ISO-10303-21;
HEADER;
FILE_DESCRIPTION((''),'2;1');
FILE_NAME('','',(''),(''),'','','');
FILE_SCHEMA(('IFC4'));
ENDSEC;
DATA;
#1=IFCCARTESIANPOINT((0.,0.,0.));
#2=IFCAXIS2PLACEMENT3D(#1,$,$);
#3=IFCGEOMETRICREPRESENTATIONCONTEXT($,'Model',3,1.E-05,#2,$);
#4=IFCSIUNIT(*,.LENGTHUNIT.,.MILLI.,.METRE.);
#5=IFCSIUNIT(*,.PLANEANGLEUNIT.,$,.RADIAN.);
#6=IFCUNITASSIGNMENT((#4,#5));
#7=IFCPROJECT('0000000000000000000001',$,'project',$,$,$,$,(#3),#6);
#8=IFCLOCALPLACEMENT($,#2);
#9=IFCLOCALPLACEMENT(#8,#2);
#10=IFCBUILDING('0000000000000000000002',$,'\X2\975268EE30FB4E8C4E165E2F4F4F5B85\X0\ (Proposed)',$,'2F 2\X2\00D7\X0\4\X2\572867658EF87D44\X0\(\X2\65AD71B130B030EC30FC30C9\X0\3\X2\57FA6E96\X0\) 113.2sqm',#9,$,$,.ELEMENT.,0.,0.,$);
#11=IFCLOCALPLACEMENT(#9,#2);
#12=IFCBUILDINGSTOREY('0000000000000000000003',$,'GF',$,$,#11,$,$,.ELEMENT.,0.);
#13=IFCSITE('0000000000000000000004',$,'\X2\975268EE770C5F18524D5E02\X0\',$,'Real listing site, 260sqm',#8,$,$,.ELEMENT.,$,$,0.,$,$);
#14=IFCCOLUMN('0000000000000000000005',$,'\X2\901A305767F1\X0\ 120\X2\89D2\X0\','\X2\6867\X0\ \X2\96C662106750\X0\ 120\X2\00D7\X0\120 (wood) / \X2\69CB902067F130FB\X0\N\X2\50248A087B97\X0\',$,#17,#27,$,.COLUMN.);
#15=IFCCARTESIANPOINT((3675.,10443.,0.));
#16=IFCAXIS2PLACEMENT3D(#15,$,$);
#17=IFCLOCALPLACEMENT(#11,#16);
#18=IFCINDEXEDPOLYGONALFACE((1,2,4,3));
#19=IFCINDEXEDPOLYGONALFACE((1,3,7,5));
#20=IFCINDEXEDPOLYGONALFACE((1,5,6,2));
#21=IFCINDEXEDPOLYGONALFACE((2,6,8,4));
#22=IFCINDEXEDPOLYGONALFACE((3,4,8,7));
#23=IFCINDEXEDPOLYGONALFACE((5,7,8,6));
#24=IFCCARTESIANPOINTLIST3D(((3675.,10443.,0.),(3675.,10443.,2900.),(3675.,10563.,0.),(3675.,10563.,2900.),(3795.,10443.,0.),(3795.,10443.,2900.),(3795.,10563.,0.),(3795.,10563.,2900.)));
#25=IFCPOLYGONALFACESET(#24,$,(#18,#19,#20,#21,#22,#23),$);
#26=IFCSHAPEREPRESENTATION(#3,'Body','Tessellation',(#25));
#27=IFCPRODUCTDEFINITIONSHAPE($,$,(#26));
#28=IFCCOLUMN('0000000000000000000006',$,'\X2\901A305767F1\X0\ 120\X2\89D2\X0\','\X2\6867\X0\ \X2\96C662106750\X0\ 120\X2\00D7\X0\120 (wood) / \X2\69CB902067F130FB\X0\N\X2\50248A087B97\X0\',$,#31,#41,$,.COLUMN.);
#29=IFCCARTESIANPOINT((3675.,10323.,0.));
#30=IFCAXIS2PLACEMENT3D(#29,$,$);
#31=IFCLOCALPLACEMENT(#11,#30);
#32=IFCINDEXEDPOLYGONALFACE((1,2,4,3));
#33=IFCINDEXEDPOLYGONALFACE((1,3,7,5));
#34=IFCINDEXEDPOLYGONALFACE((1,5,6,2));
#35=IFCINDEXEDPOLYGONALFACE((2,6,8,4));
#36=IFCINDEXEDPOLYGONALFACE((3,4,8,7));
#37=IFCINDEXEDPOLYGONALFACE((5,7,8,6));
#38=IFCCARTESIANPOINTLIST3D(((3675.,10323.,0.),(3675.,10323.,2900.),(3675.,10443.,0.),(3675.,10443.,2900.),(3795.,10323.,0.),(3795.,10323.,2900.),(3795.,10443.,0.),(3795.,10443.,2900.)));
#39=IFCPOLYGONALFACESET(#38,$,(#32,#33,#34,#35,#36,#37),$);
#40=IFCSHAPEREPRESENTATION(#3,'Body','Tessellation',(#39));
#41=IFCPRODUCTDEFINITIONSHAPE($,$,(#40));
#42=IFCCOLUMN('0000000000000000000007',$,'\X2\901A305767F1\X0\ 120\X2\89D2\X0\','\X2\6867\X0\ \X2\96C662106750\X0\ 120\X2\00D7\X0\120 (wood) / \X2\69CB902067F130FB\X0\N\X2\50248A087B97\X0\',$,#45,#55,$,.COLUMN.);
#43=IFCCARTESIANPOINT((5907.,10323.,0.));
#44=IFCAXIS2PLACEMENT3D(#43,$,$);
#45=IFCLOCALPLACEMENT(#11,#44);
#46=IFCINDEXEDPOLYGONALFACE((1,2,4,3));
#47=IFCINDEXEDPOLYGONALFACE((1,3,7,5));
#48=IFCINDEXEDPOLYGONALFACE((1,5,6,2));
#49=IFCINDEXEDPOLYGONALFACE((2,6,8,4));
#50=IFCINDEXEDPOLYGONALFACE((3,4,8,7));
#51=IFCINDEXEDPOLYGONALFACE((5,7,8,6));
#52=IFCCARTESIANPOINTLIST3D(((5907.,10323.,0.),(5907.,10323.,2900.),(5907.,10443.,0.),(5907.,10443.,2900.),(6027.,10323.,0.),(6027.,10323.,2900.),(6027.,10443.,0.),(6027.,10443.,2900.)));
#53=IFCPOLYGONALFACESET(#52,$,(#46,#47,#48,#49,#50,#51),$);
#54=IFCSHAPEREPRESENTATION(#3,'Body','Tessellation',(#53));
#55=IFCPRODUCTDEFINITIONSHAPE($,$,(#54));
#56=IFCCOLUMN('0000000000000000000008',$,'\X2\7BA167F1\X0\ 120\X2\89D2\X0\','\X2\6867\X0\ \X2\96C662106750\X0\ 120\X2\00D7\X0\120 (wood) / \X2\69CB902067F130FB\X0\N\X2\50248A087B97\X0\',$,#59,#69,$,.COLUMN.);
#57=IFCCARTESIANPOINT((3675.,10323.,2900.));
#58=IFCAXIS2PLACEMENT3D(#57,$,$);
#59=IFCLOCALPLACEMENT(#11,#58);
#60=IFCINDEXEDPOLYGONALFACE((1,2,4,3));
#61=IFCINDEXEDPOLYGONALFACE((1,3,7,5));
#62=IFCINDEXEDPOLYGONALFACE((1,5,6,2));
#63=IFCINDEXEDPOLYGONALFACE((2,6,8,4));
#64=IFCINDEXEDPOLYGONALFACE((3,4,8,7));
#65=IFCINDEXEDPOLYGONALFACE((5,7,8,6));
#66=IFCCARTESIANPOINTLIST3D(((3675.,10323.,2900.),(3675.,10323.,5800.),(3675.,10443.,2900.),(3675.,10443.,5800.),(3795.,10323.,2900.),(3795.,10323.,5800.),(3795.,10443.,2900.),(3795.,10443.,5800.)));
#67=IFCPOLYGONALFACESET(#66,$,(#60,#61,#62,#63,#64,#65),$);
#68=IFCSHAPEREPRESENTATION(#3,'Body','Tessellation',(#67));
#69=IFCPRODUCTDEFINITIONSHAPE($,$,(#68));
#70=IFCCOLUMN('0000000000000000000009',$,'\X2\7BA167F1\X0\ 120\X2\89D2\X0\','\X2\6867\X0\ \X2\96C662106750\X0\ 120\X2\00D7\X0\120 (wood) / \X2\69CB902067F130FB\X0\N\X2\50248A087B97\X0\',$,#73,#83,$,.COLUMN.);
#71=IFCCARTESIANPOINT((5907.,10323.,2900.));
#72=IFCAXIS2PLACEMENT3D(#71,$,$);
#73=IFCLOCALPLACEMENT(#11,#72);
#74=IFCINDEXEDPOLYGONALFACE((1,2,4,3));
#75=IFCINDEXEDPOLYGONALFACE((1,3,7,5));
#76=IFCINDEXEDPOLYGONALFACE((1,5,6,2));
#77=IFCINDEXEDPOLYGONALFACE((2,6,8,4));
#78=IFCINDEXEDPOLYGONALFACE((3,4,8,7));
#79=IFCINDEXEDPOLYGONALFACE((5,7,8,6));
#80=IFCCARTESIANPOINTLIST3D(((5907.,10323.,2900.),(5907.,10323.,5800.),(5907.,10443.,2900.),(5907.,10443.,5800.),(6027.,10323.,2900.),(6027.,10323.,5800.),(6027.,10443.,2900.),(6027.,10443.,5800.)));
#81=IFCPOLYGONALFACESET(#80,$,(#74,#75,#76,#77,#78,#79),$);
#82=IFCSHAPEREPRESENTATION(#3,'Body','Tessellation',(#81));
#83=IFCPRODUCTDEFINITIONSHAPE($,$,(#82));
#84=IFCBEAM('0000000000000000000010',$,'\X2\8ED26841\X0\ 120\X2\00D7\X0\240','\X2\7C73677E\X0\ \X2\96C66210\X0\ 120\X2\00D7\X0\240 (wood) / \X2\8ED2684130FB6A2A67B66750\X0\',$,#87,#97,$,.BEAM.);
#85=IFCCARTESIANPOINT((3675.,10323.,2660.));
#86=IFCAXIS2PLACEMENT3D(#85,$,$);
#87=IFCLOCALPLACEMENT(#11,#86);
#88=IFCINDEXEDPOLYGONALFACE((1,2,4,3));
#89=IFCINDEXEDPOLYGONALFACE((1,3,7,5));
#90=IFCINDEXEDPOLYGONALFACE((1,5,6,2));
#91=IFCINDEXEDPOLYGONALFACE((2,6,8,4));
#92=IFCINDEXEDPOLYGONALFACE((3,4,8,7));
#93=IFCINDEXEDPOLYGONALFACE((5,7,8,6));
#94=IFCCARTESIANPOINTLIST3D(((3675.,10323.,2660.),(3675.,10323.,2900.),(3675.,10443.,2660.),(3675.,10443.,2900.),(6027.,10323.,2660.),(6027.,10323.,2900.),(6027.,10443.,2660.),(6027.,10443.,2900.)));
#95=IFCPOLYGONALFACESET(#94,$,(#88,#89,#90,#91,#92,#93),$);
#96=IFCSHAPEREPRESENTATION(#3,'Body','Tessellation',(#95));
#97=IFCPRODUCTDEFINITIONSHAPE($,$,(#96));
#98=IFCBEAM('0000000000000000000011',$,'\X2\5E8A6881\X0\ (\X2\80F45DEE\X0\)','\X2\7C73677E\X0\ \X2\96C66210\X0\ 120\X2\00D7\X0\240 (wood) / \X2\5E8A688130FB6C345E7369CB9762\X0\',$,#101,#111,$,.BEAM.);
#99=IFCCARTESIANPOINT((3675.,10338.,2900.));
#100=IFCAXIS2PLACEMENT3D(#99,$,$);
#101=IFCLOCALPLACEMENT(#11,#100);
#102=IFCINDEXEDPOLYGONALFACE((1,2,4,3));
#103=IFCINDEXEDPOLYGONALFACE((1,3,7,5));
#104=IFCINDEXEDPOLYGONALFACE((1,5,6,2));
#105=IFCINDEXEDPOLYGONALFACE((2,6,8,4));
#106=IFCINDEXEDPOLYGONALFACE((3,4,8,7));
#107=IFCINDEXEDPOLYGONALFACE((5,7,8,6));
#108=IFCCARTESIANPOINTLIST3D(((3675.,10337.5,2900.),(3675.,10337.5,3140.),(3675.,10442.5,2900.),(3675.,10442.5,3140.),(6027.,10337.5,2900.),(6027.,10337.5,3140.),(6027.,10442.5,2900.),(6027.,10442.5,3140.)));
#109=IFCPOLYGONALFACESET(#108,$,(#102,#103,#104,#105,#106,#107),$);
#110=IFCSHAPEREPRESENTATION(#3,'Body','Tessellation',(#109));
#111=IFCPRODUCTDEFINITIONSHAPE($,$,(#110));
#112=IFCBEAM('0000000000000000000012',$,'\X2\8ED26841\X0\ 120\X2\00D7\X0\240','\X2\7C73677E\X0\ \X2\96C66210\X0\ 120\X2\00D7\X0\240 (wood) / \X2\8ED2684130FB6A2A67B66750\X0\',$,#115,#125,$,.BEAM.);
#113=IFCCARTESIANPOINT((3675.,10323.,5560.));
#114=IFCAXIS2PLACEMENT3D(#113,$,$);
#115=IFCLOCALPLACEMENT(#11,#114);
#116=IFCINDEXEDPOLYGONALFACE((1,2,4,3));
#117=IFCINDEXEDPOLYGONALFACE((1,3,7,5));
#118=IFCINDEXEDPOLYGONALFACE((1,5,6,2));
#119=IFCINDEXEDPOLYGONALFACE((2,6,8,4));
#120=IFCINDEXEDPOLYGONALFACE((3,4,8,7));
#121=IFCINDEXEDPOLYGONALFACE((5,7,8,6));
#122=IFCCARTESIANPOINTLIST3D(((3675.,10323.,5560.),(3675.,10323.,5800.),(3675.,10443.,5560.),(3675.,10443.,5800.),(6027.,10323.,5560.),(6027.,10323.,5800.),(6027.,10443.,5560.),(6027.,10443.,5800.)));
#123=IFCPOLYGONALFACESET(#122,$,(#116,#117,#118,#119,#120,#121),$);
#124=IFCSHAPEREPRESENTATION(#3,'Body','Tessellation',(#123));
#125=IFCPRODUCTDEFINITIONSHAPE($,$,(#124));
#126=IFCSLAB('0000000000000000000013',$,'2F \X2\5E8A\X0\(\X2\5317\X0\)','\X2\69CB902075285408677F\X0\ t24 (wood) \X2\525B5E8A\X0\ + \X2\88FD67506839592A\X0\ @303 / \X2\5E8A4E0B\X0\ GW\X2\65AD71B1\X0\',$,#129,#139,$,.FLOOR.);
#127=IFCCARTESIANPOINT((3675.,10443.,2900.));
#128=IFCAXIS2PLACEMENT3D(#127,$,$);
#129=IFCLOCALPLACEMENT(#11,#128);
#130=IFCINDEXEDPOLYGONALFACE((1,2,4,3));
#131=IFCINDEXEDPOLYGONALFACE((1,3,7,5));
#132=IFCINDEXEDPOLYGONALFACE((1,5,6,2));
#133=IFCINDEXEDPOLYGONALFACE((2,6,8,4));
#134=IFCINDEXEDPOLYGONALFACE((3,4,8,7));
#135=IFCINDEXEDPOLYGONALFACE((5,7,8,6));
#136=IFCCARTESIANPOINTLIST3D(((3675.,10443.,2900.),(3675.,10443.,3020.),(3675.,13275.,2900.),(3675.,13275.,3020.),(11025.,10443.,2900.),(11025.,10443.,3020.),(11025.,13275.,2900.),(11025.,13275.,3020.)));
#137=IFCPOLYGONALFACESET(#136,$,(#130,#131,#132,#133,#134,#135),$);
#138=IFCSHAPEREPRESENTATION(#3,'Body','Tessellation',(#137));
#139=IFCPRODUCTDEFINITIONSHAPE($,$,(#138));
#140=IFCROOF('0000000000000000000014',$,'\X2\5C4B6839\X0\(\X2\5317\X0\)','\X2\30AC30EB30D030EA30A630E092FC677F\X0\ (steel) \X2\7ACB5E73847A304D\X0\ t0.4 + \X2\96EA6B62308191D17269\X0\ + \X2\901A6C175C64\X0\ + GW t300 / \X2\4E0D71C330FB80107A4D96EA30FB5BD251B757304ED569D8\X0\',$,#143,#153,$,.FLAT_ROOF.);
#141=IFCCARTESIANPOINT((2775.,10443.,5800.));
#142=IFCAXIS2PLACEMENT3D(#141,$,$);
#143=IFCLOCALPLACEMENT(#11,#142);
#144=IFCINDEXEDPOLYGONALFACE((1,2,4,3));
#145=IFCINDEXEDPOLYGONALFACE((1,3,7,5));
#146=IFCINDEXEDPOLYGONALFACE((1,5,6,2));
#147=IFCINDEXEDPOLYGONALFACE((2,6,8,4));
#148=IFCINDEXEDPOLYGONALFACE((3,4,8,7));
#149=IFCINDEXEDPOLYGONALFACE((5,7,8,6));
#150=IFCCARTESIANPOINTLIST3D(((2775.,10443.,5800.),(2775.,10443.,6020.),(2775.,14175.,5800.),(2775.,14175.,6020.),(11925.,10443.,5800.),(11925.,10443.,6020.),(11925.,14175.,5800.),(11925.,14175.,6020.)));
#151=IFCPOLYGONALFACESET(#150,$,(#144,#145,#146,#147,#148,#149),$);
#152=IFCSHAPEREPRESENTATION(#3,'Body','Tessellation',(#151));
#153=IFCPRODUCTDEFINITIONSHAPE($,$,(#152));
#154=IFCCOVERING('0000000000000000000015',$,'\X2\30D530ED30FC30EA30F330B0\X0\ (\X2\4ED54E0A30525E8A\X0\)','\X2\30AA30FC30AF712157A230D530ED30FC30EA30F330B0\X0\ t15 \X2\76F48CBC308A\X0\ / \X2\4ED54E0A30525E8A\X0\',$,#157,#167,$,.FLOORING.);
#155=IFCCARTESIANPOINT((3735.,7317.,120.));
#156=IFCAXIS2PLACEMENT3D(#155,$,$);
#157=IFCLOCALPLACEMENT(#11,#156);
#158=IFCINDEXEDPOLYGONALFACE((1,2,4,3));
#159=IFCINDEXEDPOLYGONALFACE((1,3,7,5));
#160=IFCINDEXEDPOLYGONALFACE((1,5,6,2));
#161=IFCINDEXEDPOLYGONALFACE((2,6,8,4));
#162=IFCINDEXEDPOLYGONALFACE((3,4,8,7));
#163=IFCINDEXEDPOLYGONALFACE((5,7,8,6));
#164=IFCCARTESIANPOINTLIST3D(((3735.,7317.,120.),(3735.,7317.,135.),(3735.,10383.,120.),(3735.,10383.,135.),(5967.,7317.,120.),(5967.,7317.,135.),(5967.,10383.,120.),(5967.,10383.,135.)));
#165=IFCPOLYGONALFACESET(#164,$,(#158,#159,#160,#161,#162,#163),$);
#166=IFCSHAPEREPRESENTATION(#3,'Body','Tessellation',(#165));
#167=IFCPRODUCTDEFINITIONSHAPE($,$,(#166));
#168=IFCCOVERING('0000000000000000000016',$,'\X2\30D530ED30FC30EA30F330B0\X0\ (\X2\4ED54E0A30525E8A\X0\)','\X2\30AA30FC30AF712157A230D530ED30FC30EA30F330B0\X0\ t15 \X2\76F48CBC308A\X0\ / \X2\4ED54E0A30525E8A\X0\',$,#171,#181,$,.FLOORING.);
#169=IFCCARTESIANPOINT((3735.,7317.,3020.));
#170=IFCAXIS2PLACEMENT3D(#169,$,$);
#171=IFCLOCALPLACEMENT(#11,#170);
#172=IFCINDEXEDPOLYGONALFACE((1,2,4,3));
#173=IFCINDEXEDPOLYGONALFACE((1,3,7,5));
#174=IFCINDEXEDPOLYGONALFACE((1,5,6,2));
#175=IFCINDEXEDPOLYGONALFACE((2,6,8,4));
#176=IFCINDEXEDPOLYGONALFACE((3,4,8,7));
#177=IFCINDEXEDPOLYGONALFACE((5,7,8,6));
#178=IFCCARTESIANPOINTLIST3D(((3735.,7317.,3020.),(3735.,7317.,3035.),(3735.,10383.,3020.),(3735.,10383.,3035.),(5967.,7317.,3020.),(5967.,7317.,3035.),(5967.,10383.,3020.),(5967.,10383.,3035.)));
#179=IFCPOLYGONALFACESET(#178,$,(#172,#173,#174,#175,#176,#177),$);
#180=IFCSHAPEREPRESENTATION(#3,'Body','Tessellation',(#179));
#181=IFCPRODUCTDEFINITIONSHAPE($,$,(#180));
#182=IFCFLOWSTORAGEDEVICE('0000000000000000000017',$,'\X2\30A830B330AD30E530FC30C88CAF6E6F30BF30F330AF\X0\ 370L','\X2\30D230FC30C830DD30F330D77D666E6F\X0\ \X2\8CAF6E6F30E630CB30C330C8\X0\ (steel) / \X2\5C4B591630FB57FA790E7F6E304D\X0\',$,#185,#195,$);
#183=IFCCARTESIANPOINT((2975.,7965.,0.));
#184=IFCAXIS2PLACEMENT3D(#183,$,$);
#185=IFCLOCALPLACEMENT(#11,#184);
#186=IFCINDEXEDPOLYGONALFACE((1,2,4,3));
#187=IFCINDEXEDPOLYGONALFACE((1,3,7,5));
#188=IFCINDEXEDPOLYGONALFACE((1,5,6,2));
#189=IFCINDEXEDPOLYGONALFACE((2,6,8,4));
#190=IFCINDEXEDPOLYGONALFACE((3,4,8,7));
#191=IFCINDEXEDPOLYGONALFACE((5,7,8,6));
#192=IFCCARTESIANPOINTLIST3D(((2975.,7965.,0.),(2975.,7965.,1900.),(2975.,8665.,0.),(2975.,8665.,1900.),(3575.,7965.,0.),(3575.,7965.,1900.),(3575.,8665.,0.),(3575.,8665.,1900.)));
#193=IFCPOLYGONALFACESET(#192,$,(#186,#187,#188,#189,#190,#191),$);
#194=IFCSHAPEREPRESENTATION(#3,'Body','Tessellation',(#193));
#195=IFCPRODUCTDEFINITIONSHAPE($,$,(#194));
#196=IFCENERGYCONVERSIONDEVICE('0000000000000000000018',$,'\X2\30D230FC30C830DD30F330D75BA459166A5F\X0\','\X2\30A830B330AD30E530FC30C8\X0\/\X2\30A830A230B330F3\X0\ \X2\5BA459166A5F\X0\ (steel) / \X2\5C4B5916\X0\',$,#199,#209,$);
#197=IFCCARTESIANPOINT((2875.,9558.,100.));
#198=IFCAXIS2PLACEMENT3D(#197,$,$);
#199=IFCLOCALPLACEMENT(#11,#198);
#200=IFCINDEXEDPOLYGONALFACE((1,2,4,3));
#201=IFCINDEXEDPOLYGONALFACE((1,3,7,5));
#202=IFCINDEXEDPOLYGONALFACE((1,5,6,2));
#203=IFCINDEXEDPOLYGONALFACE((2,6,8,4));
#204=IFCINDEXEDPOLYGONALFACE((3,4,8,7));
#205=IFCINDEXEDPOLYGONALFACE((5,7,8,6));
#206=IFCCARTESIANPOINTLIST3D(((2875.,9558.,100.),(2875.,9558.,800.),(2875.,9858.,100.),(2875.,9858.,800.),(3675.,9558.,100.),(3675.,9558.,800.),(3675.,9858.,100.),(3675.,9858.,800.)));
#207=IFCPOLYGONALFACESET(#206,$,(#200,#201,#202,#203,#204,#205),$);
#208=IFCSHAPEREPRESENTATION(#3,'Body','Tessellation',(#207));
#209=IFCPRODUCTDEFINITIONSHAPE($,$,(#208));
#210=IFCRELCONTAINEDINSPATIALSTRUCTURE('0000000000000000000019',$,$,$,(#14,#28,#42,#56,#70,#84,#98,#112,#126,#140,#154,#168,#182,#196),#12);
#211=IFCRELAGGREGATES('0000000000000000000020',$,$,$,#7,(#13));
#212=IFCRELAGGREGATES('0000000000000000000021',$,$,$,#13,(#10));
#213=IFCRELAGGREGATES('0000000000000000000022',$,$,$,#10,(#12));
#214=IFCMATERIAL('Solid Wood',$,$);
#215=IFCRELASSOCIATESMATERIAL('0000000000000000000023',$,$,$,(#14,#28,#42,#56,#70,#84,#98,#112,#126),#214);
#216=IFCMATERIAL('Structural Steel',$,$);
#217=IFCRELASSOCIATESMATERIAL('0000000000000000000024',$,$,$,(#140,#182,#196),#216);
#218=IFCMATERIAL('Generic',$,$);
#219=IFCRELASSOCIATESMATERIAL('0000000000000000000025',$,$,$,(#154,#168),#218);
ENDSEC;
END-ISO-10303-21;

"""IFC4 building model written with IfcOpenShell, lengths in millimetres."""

from ifc_helpers import new_model, si_unit, frame, frame_2d, origin, place, context, project, spatial, rectangle, extrude, material, element, save


model = new_model("IFC4")

# Units and contexts
model_context = context("Model", 3, precision=1e-05, world=origin())
ifc_project = project(units=[si_unit("LENGTHUNIT", "METRE", prefix="MILLI"), si_unit("PLANEANGLEUNIT", "RADIAN")], contexts=[model_context])

# Site, building, storey
site_placement = place(None, origin())
site = spatial("IfcSite", under=ifc_project, at=site_placement, Name="青森県弘前市", ObjectType="Real listing site, 260sqm", CompositionType="ELEMENT", RefElevation=0.0)
building_placement = place(site_placement, origin())
building = spatial("IfcBuilding", under=site, at=building_placement, Name="青森・二世帯住宅 (Proposed)", ObjectType="2F 2×4在来軸組(断熱グレード3基準) 113.2sqm", CompositionType="ELEMENT", ElevationOfRefHeight=0.0, ElevationOfTerrain=0.0)
storey_placement = place(building_placement, origin())
storey = spatial("IfcBuildingStorey", under=building, at=storey_placement, Name="GF", CompositionType="ELEMENT", Elevation=0.0)

# Columns
ifc_material_1 = material(Name="Solid Wood")
column_1_placement = place(storey_placement, frame((3675.0, 10443.0, 0.0)))
element("IfcColumn", 1, at=column_1_placement, inside=storey, material=ifc_material_1, Name="通し柱 120角", Description="桧 集成材 120×120 (wood) / 構造柱・N値計算", PredefinedType="COLUMN", context=model_context, shape_type="SweptSolid", body=[
    extrude(rectangle(XDim=120.0, YDim=120.0, at=frame_2d((60.0, 60.0))), frame((3675.0, 10443.0, 0.0)), (0.0, 0.0, 1.0), 2900.0),
])
column_2_placement = place(storey_placement, frame((3675.0, 10323.0, 0.0)))
element("IfcColumn", 2, at=column_2_placement, inside=storey, material=ifc_material_1, Name="通し柱 120角", Description="桧 集成材 120×120 (wood) / 構造柱・N値計算", PredefinedType="COLUMN", context=model_context, shape_type="SweptSolid", body=[
    extrude(rectangle(XDim=120.0, YDim=120.0, at=frame_2d((60.0, 60.0))), frame((3675.0, 10323.0, 0.0)), (0.0, 0.0, 1.0), 2900.0),
])
column_3_placement = place(storey_placement, frame((5907.0, 10323.0, 0.0)))
element("IfcColumn", 3, at=column_3_placement, inside=storey, material=ifc_material_1, Name="通し柱 120角", Description="桧 集成材 120×120 (wood) / 構造柱・N値計算", PredefinedType="COLUMN", context=model_context, shape_type="SweptSolid", body=[
    extrude(rectangle(XDim=120.0, YDim=120.0, at=frame_2d((60.0, 60.0))), frame((5907.0, 10323.0, 0.0)), (0.0, 0.0, 1.0), 2900.0),
])
column_4_placement = place(storey_placement, frame((3675.0, 10323.0, 2900.0)))
element("IfcColumn", 4, at=column_4_placement, inside=storey, material=ifc_material_1, Name="管柱 120角", Description="桧 集成材 120×120 (wood) / 構造柱・N値計算", PredefinedType="COLUMN", context=model_context, shape_type="SweptSolid", body=[
    extrude(rectangle(XDim=120.0, YDim=120.0, at=frame_2d((60.0, 60.0))), frame((3675.0, 10323.0, 2900.0)), (0.0, 0.0, 1.0), 2900.0),
])
column_5_placement = place(storey_placement, frame((5907.0, 10323.0, 2900.0)))
element("IfcColumn", 5, at=column_5_placement, inside=storey, material=ifc_material_1, Name="管柱 120角", Description="桧 集成材 120×120 (wood) / 構造柱・N値計算", PredefinedType="COLUMN", context=model_context, shape_type="SweptSolid", body=[
    extrude(rectangle(XDim=120.0, YDim=120.0, at=frame_2d((60.0, 60.0))), frame((5907.0, 10323.0, 2900.0)), (0.0, 0.0, 1.0), 2900.0),
])

# Beams
beam_1_placement = place(storey_placement, frame((3675.0, 10323.0, 2660.0)))
element("IfcBeam", 6, at=beam_1_placement, inside=storey, material=ifc_material_1, Name="軒桁 120×240", Description="米松 集成 120×240 (wood) / 軒桁・横架材", PredefinedType="BEAM", context=model_context, shape_type="SweptSolid", body=[
    extrude(rectangle(XDim=2352.0, YDim=120.0, at=frame_2d((1176.0, 60.0))), frame((3675.0, 10323.0, 2660.0)), (0.0, 0.0, 1.0), 240.0),
])
beam_2_placement = place(storey_placement, frame((3675.0, 10338.0, 2900.0)))
element("IfcBeam", 7, at=beam_2_placement, inside=storey, material=ifc_material_1, Name="床梁 (胴差)", Description="米松 集成 120×240 (wood) / 床梁・水平構面", PredefinedType="BEAM", context=model_context, shape_type="SweptSolid", body=[
    extrude(rectangle(XDim=2352.0, YDim=105.0, at=frame_2d((1176.0, 52.0))), frame((3675.0, 10338.0, 2900.0)), (0.0, 0.0, 1.0), 240.0),
])
beam_3_placement = place(storey_placement, frame((3675.0, 10323.0, 5560.0)))
element("IfcBeam", 8, at=beam_3_placement, inside=storey, material=ifc_material_1, Name="軒桁 120×240", Description="米松 集成 120×240 (wood) / 軒桁・横架材", PredefinedType="BEAM", context=model_context, shape_type="SweptSolid", body=[
    extrude(rectangle(XDim=2352.0, YDim=120.0, at=frame_2d((1176.0, 60.0))), frame((3675.0, 10323.0, 5560.0)), (0.0, 0.0, 1.0), 240.0),
])

# Slab
slab_1_placement = place(storey_placement, frame((3675.0, 10443.0, 2900.0)))
element("IfcSlab", 9, at=slab_1_placement, inside=storey, material=ifc_material_1, Name="2F 床(北)", Description="構造用合板 t24 (wood) 剛床 + 製材根太 @303 / 床下 GW断熱", PredefinedType="FLOOR", context=model_context, shape_type="SweptSolid", body=[
    extrude(rectangle(XDim=7350.0, YDim=2832.0, at=frame_2d((3675.0, 1416.0))), frame((3675.0, 10443.0, 2900.0)), (0.0, 0.0, 1.0), 120.0),
])

# Roof
ifc_material_2 = material(Name="Structural Steel")
for number, where, name in (
    (10, (2775.0, 10443.0, 5800.0), "屋根(北)"),
):
    element("IfcRoof", number, at=place(storey_placement, frame(where)), inside=storey, material=ifc_material_2, Name=name, Description="ガルバリウム鋼板 (steel) 立平葺き t0.4 + 雪止め金物 + 通気層 + GW t300 / 不燃・耐積雪・寒冷地仕様", PredefinedType="FLAT_ROOF", context=model_context, shape_type="SweptSolid", body=[
        extrude(rectangle(XDim=9150.0, YDim=3732.0, at=frame_2d((4575.0, 1866.0))), frame((2775.0, 10443.0, 5800.0)), (0.0, 0.0, 1.0), 220.0),
    ])

# Coverings
ifc_material_3 = material(Name="Generic")
covering_1_placement = place(storey_placement, frame((3735.0, 7317.0, 120.0)))
element("IfcCovering", 11, at=covering_1_placement, inside=storey, material=ifc_material_3, Name="フローリング (仕上げ床)", Description="オーク無垢フローリング t15 直貼り / 仕上げ床", PredefinedType="FLOORING", context=model_context, shape_type="SweptSolid", body=[
    extrude(rectangle(XDim=2232.0, YDim=3066.0, at=frame_2d((1116.0, 1533.0))), frame((3735.0, 7317.0, 120.0)), (0.0, 0.0, 1.0), 15.0),
])
covering_2_placement = place(storey_placement, frame((3735.0, 7317.0, 3020.0)))
element("IfcCovering", 12, at=covering_2_placement, inside=storey, material=ifc_material_3, Name="フローリング (仕上げ床)", Description="オーク無垢フローリング t15 直貼り / 仕上げ床", PredefinedType="FLOORING", context=model_context, shape_type="SweptSolid", body=[
    extrude(rectangle(XDim=2232.0, YDim=3066.0, at=frame_2d((1116.0, 1533.0))), frame((3735.0, 7317.0, 3020.0)), (0.0, 0.0, 1.0), 15.0),
])

# Flow storage device
flow_storage_device_placement = place(storey_placement, frame((2975.0, 7965.0, 0.0)))
element("IfcFlowStorageDevice", 13, at=flow_storage_device_placement, inside=storey, material=ifc_material_2, Name="エコキュート貯湯タンク 370L", Description="ヒートポンプ給湯 貯湯ユニット (steel) / 屋外・基礎置き", context=model_context, shape_type="SweptSolid", body=[
    extrude(rectangle(XDim=600.0, YDim=700.0, at=frame_2d((300.0, 350.0))), frame((2975.0, 7965.0, 0.0)), (0.0, 0.0, 1.0), 1900.0),
])

# Energy conversion device
energy_conversion_device_placement = place(storey_placement, frame((2875.0, 9558.0, 100.0)))
element("IfcEnergyConversionDevice", 14, at=energy_conversion_device_placement, inside=storey, material=ifc_material_2, Name="ヒートポンプ室外機", Description="エコキュート/エアコン 室外機 (steel) / 屋外", context=model_context, shape_type="SweptSolid", body=[
    extrude(rectangle(XDim=800.0, YDim=300.0, at=frame_2d((400.0, 150.0))), frame((2875.0, 9558.0, 100.0)), (0.0, 0.0, 1.0), 700.0),
])

save(model, "model.ifc")
